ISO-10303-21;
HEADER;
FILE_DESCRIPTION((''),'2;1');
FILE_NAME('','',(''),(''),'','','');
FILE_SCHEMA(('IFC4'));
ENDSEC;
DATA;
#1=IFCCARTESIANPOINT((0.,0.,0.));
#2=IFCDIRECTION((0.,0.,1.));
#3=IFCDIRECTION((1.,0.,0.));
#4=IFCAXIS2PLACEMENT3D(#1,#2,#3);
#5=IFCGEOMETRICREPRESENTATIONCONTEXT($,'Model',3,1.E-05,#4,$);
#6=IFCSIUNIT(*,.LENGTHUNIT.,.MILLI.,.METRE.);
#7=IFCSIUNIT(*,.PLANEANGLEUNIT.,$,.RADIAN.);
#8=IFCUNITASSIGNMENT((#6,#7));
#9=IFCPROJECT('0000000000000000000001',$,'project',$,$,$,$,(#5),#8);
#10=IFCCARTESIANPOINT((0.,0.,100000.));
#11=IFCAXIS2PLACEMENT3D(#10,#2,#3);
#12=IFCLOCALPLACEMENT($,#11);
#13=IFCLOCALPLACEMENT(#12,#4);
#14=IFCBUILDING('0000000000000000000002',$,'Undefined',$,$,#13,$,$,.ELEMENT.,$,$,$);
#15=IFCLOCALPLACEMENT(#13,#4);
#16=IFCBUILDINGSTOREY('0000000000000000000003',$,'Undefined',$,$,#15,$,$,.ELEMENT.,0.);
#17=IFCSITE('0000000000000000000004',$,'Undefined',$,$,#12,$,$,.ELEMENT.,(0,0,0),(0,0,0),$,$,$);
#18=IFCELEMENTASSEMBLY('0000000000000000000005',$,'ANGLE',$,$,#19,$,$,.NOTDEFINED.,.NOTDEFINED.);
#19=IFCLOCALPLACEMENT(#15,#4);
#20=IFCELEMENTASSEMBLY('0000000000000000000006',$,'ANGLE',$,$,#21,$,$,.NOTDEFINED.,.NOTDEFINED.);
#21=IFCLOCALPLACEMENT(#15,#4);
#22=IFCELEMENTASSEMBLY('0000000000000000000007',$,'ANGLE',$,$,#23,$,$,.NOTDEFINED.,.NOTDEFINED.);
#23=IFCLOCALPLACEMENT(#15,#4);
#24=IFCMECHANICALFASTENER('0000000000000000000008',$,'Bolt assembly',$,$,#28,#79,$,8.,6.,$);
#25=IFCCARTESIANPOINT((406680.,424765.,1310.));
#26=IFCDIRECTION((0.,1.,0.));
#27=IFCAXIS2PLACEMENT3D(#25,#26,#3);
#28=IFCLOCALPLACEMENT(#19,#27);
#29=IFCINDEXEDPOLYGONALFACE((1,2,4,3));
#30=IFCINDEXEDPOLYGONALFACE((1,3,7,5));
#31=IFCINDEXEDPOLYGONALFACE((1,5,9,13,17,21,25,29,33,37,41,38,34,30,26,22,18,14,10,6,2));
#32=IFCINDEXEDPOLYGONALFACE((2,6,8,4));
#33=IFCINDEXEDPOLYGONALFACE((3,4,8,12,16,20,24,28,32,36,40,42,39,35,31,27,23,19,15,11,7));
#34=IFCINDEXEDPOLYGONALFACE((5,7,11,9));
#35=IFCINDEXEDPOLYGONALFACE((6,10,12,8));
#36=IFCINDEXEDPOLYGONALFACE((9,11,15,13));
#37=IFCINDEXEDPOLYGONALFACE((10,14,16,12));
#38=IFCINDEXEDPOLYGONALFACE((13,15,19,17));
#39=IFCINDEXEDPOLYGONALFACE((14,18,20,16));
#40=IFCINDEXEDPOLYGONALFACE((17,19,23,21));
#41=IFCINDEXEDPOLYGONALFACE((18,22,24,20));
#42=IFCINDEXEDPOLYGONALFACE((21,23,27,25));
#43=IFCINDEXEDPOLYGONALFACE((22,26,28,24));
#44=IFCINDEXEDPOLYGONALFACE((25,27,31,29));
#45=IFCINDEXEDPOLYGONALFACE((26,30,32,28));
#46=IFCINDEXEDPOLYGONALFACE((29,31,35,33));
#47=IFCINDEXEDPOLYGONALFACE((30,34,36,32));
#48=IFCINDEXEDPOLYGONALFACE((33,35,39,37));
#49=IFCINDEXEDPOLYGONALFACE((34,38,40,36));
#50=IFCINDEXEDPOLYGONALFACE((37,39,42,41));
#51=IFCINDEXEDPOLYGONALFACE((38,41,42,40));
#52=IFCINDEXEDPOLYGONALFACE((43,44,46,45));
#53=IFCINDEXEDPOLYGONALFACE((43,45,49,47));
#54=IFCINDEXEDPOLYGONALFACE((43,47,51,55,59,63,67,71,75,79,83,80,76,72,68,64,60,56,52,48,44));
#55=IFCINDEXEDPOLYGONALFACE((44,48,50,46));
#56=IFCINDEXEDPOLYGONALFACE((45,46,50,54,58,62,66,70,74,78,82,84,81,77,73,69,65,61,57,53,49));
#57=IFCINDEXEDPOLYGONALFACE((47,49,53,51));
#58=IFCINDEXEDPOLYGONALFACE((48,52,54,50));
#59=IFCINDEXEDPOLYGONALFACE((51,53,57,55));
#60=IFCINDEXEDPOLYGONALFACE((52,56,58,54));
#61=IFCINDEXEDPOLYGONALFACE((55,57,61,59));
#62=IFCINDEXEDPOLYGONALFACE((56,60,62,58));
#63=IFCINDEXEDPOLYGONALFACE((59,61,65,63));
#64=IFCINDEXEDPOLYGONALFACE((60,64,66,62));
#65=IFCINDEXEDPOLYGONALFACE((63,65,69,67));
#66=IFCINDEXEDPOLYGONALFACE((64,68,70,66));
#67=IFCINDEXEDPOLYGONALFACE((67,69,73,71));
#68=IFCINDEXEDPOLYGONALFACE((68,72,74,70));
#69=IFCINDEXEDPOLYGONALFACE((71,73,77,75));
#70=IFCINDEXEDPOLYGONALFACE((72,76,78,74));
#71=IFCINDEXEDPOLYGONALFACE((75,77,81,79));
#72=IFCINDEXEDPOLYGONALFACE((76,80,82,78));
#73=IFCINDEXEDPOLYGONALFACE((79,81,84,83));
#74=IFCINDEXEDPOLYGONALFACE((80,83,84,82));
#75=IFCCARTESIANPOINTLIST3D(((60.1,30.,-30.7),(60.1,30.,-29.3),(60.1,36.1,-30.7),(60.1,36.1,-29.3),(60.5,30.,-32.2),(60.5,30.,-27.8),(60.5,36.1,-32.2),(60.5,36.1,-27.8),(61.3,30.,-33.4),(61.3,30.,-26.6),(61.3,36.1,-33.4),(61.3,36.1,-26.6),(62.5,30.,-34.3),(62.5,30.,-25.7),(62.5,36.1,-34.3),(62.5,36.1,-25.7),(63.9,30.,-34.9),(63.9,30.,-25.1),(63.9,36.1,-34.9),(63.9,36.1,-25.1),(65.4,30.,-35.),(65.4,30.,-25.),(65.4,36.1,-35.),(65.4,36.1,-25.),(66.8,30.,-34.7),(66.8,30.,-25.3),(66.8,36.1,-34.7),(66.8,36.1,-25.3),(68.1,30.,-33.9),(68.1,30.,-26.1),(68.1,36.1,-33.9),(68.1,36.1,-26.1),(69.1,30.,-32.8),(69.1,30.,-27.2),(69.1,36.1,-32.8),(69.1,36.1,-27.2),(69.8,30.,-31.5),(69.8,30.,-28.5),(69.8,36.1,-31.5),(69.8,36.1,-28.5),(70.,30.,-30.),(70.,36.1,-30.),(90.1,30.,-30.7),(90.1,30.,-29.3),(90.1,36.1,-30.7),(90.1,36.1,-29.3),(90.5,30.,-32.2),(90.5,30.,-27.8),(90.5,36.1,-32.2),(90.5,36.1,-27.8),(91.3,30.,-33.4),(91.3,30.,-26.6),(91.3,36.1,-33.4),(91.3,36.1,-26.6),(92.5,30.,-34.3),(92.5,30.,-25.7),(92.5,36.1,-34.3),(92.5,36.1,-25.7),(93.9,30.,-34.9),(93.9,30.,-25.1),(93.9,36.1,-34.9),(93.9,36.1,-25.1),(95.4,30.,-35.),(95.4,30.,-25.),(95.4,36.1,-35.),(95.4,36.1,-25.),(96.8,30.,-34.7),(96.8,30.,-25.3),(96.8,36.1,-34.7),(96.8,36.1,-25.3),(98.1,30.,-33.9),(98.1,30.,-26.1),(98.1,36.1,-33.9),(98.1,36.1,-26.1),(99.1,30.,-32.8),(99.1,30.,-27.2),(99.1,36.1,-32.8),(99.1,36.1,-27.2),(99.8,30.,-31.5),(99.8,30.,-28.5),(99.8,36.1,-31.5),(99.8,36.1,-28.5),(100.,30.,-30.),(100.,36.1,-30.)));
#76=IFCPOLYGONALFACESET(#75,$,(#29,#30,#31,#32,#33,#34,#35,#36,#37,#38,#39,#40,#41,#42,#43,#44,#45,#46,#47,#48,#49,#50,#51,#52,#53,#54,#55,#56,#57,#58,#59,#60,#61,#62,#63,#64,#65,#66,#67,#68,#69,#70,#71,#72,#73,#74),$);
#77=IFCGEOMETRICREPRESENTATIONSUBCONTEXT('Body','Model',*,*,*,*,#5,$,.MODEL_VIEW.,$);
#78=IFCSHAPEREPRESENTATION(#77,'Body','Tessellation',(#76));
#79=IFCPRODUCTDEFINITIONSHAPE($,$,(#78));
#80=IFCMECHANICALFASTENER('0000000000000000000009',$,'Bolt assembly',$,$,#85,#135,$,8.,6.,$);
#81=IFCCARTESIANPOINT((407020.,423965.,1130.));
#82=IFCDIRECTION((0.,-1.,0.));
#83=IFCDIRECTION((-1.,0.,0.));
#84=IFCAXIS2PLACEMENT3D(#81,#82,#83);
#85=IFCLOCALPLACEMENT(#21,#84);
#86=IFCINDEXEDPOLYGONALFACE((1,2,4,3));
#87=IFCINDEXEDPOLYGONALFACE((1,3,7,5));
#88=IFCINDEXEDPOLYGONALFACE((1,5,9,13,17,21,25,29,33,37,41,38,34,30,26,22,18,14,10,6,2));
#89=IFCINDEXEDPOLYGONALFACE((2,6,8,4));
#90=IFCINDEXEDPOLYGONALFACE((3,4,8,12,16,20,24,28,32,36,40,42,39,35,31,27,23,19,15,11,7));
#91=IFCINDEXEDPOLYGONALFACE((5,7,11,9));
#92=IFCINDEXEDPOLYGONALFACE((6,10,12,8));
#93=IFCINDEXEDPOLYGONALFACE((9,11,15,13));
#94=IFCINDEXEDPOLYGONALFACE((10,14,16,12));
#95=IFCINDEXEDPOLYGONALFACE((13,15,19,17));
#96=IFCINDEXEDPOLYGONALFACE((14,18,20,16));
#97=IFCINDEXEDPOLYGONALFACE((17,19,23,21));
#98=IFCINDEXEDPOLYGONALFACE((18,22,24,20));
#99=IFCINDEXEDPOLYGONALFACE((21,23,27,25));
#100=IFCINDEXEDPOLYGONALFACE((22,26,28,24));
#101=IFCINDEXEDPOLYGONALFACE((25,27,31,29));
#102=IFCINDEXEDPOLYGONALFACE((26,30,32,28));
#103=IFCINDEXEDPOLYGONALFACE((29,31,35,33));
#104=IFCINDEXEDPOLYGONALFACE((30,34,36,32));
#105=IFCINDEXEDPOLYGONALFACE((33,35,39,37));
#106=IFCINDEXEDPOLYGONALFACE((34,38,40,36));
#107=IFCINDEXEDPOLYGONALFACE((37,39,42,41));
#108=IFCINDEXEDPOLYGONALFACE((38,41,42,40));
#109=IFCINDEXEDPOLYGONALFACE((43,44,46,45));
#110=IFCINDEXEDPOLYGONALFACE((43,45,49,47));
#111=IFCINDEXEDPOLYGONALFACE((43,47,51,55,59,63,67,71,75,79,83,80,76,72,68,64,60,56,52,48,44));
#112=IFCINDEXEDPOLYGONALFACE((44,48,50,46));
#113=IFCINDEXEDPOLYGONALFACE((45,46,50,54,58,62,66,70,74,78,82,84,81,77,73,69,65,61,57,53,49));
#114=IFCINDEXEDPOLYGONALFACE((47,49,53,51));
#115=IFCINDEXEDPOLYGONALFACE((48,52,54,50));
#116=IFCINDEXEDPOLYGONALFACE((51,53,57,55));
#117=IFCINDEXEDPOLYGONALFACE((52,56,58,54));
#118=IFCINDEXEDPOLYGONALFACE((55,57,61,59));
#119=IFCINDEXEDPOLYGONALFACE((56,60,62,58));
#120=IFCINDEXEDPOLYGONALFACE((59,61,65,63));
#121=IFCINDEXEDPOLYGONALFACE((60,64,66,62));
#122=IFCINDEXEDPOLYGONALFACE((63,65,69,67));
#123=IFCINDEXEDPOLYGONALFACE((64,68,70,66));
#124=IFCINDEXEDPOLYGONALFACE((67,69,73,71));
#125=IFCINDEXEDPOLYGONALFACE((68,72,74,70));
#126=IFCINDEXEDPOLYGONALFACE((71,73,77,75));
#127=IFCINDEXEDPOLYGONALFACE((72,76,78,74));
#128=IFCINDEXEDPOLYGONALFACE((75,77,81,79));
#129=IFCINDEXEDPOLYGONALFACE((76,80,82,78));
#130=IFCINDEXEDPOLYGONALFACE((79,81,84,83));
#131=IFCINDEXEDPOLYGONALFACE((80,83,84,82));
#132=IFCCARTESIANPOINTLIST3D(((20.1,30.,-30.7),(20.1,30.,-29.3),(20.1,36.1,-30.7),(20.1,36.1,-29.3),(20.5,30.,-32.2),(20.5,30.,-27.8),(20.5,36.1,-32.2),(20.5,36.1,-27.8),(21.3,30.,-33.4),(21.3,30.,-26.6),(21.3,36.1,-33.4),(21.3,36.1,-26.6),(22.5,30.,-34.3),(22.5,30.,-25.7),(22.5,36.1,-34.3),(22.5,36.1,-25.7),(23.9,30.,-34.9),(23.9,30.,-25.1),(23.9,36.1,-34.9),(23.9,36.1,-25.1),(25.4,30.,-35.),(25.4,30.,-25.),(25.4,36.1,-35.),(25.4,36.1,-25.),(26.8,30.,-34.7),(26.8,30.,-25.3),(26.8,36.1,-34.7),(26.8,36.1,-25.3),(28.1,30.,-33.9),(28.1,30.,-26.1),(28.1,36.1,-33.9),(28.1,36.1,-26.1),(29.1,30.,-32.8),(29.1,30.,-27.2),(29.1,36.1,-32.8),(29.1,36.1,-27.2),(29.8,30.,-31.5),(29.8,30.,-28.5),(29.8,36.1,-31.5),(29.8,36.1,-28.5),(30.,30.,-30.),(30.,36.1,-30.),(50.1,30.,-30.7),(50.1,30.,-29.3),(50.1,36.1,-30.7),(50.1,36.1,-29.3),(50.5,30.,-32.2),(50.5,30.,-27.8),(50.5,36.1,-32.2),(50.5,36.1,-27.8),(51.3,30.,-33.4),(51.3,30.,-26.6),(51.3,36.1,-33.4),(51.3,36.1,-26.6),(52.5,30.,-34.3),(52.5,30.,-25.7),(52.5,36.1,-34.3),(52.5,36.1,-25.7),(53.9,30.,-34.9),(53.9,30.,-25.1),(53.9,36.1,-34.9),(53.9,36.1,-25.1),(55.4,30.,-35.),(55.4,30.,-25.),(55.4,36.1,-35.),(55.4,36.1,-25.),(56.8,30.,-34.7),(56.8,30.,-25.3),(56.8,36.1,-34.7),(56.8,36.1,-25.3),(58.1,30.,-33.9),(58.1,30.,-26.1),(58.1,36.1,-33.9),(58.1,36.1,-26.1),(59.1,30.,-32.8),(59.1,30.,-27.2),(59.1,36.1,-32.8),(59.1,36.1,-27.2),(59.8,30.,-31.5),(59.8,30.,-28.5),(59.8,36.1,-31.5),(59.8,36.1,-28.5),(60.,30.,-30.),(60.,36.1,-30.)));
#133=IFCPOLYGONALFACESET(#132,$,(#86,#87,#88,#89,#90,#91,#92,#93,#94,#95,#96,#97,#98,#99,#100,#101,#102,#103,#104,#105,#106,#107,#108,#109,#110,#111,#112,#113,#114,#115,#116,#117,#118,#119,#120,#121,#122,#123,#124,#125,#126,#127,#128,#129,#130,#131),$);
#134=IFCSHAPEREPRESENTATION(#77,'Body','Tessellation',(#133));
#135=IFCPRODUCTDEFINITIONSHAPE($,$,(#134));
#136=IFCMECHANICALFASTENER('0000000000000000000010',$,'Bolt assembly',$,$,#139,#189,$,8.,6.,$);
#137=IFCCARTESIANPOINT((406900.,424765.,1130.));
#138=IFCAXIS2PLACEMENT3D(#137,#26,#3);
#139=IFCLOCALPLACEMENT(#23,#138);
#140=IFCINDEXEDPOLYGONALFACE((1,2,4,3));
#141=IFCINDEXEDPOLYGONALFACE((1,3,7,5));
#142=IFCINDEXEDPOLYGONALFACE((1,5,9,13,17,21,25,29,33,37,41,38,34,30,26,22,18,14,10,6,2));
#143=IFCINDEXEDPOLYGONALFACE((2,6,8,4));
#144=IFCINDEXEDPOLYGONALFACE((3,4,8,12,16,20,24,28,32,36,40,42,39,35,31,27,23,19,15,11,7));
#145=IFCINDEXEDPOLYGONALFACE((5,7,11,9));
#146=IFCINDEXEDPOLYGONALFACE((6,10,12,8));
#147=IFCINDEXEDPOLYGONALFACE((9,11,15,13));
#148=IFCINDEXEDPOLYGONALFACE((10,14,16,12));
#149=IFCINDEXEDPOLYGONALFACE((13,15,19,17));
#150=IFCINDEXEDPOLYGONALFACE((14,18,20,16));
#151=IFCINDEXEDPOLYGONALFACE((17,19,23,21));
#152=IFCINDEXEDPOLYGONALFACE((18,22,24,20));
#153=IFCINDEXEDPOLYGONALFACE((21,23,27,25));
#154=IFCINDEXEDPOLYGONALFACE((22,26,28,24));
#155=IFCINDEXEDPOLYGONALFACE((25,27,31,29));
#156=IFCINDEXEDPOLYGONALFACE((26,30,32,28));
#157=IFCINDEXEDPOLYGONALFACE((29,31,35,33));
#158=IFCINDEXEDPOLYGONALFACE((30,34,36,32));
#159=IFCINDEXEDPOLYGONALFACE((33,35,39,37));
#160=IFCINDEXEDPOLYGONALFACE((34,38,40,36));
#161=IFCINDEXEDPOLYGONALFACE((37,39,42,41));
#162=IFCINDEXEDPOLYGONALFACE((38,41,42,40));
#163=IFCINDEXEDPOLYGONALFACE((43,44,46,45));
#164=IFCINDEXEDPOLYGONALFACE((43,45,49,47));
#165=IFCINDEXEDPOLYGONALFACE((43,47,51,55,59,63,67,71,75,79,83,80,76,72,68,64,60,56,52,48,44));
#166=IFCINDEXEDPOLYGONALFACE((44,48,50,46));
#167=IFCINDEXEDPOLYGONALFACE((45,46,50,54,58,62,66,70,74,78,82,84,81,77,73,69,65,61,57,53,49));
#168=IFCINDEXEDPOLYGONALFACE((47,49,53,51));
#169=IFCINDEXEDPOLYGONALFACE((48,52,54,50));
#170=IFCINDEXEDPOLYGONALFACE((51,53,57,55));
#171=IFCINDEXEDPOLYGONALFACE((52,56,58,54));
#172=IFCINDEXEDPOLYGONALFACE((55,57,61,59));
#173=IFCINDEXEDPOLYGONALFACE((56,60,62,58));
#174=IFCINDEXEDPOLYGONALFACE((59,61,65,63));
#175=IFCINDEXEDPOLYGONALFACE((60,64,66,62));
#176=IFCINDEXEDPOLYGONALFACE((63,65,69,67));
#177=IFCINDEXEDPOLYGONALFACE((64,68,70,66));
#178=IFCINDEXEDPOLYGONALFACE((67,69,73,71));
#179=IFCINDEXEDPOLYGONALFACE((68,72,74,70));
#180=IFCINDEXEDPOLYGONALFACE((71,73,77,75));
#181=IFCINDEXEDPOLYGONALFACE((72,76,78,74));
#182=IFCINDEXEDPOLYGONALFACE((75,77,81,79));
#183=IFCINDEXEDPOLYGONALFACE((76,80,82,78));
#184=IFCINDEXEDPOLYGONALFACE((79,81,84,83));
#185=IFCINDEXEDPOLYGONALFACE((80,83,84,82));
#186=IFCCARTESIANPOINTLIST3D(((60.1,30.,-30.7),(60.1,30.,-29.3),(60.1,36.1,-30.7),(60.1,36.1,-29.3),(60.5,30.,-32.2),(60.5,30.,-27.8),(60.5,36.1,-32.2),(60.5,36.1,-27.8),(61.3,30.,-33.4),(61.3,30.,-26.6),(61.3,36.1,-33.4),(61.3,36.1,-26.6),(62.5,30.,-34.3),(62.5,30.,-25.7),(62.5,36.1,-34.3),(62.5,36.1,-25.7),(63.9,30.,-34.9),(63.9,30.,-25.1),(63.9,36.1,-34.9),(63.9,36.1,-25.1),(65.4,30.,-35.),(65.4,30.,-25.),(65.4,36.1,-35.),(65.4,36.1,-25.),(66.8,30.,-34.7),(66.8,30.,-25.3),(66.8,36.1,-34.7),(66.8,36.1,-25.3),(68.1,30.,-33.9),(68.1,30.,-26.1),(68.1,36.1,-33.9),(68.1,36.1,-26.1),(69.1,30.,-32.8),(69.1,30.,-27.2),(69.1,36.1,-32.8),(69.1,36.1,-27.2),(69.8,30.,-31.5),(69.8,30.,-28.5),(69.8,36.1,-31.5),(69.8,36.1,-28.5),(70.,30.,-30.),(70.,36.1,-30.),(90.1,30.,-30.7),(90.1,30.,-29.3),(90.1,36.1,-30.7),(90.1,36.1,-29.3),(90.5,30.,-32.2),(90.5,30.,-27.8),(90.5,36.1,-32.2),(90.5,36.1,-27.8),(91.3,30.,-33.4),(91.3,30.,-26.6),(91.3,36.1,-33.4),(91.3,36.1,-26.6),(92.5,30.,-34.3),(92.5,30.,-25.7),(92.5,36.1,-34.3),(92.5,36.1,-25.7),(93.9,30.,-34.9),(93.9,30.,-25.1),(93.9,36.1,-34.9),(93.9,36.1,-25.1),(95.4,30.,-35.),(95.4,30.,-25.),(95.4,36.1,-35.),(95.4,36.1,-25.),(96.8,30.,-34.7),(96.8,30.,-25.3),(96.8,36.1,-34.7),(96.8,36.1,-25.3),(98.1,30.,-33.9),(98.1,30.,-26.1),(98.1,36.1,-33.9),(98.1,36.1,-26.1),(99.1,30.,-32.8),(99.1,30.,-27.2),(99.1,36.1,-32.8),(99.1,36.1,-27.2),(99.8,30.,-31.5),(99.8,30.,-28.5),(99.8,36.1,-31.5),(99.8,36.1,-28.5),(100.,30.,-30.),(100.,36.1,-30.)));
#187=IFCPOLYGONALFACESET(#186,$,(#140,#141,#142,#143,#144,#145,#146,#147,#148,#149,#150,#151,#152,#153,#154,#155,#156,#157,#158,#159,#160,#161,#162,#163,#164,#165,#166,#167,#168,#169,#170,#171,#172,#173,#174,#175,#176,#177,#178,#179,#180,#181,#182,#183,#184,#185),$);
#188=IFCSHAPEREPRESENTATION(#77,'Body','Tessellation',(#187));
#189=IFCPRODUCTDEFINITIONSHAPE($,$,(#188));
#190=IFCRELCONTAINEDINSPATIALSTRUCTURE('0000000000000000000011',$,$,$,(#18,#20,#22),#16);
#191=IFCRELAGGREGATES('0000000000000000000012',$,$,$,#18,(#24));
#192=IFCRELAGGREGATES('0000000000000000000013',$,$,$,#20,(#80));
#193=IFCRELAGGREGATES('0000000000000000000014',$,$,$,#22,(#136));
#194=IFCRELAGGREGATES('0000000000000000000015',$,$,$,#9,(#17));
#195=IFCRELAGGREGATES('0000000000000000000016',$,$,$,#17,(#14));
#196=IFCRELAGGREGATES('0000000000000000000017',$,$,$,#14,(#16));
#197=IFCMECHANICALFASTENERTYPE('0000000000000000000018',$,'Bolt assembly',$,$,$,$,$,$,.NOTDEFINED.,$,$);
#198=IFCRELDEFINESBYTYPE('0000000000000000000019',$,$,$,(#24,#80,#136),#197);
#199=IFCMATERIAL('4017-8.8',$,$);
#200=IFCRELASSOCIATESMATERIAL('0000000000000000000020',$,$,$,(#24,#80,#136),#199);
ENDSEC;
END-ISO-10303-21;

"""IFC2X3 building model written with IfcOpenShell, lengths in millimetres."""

from ifc_helpers import new_model, si_unit, frame, origin_with_axes, origin_2d_with_axis, place, context, subcontext, project, spatial, circle, extrude, source, transform, mapped, material, type_object, element, aggregate, save


model = new_model("IFC2X3")

# Units and contexts
model_context = context("Model", 3, precision=1e-05, world=origin_with_axes())
body_context = subcontext(model_context, "Body", "Model", "MODEL_VIEW")
ifc_project = project(units=[si_unit("LENGTHUNIT", "METRE", prefix="MILLI"), si_unit("PLANEANGLEUNIT", "RADIAN")], contexts=[model_context])

# Site, building, storey
site_placement = place(None, frame((0.0, 0.0, 100000.0), z_axis=(0.0, 0.0, 1.0), x_axis=(1.0, 0.0, 0.0)))
site = spatial("IfcSite", under=ifc_project, at=site_placement, Name="Undefined", CompositionType="ELEMENT", RefLatitude=(0, 0, 0), RefLongitude=(0, 0, 0))
building_placement = place(site_placement, origin_with_axes())
building = spatial("IfcBuilding", under=site, at=building_placement, Name="Undefined", CompositionType="ELEMENT")
storey_placement = place(building_placement, origin_with_axes())
storey = spatial("IfcBuildingStorey", under=building, at=storey_placement, Name="Undefined", CompositionType="ELEMENT", Elevation=0.0)

# Element assemblies
assembly_1_placement = place(storey_placement, origin_with_axes())
assembly_1 = element("IfcElementAssembly", 1, at=assembly_1_placement, inside=storey, Name="ANGLE", AssemblyPlace="NOTDEFINED", PredefinedType="NOTDEFINED")
assembly_2_placement = place(storey_placement, origin_with_axes())
assembly_2 = element("IfcElementAssembly", 2, at=assembly_2_placement, inside=storey, Name="ANGLE", AssemblyPlace="NOTDEFINED", PredefinedType="NOTDEFINED")
assembly_3_placement = place(storey_placement, origin_with_axes())
assembly_3 = element("IfcElementAssembly", 3, at=assembly_3_placement, inside=storey, Name="ANGLE", AssemblyPlace="NOTDEFINED", PredefinedType="NOTDEFINED")

# Shared definitions
ifc_material_1 = material(Name="4017-8.8")
mechanical_fastener_type = type_object("IfcMechanicalFastenerType", Name="Bolt assembly")

# Mechanical fasteners
shared_shape_1 = source(origin_with_axes(), body_context, "Body", "SweptSolid", [
    extrude(circle(Radius=5.0, at=origin_2d_with_axis()), frame((0.0, 30.0, 0.0), z_axis=(0.0, 1.0, 0.0), x_axis=(1.0, 0.0, 0.0)), (0.0, 0.0, 1.0), 6.1),
])
mechanical_fastener_1_placement = place(assembly_1_placement, frame((406680.0, 424765.0, 1310.0), z_axis=(0.0, 1.0, 0.0), x_axis=(1.0, 0.0, 0.0)))
mechanical_fastener_1 = element("IfcMechanicalFastener", 4, at=mechanical_fastener_1_placement, type_object=mechanical_fastener_type, material=ifc_material_1, Name="Bolt assembly", NominalDiameter=8.0, NominalLength=6.0, context=body_context, shape_type="MappedRepresentation", body=[
    mapped(shared_shape_1, transform((95.0, 0.0, -30.0))),
    mapped(shared_shape_1, transform((65.0, 0.0, -30.0))),
])
aggregate(assembly_1, [mechanical_fastener_1])
mechanical_fastener_2_placement = place(assembly_2_placement, frame((407020.0, 423965.0, 1130.0), z_axis=(0.0, -1.0, 0.0), x_axis=(-1.0, 0.0, 0.0)))
mechanical_fastener_2 = element("IfcMechanicalFastener", 5, at=mechanical_fastener_2_placement, type_object=mechanical_fastener_type, material=ifc_material_1, Name="Bolt assembly", NominalDiameter=8.0, NominalLength=6.0, context=body_context, shape_type="MappedRepresentation", body=[
    mapped(shared_shape_1, transform((25.0, 0.0, -30.0))),
    mapped(shared_shape_1, transform((55.0, 0.0, -30.0))),
])
aggregate(assembly_2, [mechanical_fastener_2])
mechanical_fastener_3_placement = place(assembly_3_placement, frame((406900.0, 424765.0, 1130.0), z_axis=(0.0, 1.0, 0.0), x_axis=(1.0, 0.0, 0.0)))
mechanical_fastener_3 = element("IfcMechanicalFastener", 6, at=mechanical_fastener_3_placement, type_object=mechanical_fastener_type, material=ifc_material_1, Name="Bolt assembly", NominalDiameter=8.0, NominalLength=6.0, context=body_context, shape_type="MappedRepresentation", body=[
    mapped(shared_shape_1, transform((95.0, 0.0, -30.0))),
    mapped(shared_shape_1, transform((65.0, 0.0, -30.0))),
])
aggregate(assembly_3, [mechanical_fastener_3])

save(model, "model.ifc")
